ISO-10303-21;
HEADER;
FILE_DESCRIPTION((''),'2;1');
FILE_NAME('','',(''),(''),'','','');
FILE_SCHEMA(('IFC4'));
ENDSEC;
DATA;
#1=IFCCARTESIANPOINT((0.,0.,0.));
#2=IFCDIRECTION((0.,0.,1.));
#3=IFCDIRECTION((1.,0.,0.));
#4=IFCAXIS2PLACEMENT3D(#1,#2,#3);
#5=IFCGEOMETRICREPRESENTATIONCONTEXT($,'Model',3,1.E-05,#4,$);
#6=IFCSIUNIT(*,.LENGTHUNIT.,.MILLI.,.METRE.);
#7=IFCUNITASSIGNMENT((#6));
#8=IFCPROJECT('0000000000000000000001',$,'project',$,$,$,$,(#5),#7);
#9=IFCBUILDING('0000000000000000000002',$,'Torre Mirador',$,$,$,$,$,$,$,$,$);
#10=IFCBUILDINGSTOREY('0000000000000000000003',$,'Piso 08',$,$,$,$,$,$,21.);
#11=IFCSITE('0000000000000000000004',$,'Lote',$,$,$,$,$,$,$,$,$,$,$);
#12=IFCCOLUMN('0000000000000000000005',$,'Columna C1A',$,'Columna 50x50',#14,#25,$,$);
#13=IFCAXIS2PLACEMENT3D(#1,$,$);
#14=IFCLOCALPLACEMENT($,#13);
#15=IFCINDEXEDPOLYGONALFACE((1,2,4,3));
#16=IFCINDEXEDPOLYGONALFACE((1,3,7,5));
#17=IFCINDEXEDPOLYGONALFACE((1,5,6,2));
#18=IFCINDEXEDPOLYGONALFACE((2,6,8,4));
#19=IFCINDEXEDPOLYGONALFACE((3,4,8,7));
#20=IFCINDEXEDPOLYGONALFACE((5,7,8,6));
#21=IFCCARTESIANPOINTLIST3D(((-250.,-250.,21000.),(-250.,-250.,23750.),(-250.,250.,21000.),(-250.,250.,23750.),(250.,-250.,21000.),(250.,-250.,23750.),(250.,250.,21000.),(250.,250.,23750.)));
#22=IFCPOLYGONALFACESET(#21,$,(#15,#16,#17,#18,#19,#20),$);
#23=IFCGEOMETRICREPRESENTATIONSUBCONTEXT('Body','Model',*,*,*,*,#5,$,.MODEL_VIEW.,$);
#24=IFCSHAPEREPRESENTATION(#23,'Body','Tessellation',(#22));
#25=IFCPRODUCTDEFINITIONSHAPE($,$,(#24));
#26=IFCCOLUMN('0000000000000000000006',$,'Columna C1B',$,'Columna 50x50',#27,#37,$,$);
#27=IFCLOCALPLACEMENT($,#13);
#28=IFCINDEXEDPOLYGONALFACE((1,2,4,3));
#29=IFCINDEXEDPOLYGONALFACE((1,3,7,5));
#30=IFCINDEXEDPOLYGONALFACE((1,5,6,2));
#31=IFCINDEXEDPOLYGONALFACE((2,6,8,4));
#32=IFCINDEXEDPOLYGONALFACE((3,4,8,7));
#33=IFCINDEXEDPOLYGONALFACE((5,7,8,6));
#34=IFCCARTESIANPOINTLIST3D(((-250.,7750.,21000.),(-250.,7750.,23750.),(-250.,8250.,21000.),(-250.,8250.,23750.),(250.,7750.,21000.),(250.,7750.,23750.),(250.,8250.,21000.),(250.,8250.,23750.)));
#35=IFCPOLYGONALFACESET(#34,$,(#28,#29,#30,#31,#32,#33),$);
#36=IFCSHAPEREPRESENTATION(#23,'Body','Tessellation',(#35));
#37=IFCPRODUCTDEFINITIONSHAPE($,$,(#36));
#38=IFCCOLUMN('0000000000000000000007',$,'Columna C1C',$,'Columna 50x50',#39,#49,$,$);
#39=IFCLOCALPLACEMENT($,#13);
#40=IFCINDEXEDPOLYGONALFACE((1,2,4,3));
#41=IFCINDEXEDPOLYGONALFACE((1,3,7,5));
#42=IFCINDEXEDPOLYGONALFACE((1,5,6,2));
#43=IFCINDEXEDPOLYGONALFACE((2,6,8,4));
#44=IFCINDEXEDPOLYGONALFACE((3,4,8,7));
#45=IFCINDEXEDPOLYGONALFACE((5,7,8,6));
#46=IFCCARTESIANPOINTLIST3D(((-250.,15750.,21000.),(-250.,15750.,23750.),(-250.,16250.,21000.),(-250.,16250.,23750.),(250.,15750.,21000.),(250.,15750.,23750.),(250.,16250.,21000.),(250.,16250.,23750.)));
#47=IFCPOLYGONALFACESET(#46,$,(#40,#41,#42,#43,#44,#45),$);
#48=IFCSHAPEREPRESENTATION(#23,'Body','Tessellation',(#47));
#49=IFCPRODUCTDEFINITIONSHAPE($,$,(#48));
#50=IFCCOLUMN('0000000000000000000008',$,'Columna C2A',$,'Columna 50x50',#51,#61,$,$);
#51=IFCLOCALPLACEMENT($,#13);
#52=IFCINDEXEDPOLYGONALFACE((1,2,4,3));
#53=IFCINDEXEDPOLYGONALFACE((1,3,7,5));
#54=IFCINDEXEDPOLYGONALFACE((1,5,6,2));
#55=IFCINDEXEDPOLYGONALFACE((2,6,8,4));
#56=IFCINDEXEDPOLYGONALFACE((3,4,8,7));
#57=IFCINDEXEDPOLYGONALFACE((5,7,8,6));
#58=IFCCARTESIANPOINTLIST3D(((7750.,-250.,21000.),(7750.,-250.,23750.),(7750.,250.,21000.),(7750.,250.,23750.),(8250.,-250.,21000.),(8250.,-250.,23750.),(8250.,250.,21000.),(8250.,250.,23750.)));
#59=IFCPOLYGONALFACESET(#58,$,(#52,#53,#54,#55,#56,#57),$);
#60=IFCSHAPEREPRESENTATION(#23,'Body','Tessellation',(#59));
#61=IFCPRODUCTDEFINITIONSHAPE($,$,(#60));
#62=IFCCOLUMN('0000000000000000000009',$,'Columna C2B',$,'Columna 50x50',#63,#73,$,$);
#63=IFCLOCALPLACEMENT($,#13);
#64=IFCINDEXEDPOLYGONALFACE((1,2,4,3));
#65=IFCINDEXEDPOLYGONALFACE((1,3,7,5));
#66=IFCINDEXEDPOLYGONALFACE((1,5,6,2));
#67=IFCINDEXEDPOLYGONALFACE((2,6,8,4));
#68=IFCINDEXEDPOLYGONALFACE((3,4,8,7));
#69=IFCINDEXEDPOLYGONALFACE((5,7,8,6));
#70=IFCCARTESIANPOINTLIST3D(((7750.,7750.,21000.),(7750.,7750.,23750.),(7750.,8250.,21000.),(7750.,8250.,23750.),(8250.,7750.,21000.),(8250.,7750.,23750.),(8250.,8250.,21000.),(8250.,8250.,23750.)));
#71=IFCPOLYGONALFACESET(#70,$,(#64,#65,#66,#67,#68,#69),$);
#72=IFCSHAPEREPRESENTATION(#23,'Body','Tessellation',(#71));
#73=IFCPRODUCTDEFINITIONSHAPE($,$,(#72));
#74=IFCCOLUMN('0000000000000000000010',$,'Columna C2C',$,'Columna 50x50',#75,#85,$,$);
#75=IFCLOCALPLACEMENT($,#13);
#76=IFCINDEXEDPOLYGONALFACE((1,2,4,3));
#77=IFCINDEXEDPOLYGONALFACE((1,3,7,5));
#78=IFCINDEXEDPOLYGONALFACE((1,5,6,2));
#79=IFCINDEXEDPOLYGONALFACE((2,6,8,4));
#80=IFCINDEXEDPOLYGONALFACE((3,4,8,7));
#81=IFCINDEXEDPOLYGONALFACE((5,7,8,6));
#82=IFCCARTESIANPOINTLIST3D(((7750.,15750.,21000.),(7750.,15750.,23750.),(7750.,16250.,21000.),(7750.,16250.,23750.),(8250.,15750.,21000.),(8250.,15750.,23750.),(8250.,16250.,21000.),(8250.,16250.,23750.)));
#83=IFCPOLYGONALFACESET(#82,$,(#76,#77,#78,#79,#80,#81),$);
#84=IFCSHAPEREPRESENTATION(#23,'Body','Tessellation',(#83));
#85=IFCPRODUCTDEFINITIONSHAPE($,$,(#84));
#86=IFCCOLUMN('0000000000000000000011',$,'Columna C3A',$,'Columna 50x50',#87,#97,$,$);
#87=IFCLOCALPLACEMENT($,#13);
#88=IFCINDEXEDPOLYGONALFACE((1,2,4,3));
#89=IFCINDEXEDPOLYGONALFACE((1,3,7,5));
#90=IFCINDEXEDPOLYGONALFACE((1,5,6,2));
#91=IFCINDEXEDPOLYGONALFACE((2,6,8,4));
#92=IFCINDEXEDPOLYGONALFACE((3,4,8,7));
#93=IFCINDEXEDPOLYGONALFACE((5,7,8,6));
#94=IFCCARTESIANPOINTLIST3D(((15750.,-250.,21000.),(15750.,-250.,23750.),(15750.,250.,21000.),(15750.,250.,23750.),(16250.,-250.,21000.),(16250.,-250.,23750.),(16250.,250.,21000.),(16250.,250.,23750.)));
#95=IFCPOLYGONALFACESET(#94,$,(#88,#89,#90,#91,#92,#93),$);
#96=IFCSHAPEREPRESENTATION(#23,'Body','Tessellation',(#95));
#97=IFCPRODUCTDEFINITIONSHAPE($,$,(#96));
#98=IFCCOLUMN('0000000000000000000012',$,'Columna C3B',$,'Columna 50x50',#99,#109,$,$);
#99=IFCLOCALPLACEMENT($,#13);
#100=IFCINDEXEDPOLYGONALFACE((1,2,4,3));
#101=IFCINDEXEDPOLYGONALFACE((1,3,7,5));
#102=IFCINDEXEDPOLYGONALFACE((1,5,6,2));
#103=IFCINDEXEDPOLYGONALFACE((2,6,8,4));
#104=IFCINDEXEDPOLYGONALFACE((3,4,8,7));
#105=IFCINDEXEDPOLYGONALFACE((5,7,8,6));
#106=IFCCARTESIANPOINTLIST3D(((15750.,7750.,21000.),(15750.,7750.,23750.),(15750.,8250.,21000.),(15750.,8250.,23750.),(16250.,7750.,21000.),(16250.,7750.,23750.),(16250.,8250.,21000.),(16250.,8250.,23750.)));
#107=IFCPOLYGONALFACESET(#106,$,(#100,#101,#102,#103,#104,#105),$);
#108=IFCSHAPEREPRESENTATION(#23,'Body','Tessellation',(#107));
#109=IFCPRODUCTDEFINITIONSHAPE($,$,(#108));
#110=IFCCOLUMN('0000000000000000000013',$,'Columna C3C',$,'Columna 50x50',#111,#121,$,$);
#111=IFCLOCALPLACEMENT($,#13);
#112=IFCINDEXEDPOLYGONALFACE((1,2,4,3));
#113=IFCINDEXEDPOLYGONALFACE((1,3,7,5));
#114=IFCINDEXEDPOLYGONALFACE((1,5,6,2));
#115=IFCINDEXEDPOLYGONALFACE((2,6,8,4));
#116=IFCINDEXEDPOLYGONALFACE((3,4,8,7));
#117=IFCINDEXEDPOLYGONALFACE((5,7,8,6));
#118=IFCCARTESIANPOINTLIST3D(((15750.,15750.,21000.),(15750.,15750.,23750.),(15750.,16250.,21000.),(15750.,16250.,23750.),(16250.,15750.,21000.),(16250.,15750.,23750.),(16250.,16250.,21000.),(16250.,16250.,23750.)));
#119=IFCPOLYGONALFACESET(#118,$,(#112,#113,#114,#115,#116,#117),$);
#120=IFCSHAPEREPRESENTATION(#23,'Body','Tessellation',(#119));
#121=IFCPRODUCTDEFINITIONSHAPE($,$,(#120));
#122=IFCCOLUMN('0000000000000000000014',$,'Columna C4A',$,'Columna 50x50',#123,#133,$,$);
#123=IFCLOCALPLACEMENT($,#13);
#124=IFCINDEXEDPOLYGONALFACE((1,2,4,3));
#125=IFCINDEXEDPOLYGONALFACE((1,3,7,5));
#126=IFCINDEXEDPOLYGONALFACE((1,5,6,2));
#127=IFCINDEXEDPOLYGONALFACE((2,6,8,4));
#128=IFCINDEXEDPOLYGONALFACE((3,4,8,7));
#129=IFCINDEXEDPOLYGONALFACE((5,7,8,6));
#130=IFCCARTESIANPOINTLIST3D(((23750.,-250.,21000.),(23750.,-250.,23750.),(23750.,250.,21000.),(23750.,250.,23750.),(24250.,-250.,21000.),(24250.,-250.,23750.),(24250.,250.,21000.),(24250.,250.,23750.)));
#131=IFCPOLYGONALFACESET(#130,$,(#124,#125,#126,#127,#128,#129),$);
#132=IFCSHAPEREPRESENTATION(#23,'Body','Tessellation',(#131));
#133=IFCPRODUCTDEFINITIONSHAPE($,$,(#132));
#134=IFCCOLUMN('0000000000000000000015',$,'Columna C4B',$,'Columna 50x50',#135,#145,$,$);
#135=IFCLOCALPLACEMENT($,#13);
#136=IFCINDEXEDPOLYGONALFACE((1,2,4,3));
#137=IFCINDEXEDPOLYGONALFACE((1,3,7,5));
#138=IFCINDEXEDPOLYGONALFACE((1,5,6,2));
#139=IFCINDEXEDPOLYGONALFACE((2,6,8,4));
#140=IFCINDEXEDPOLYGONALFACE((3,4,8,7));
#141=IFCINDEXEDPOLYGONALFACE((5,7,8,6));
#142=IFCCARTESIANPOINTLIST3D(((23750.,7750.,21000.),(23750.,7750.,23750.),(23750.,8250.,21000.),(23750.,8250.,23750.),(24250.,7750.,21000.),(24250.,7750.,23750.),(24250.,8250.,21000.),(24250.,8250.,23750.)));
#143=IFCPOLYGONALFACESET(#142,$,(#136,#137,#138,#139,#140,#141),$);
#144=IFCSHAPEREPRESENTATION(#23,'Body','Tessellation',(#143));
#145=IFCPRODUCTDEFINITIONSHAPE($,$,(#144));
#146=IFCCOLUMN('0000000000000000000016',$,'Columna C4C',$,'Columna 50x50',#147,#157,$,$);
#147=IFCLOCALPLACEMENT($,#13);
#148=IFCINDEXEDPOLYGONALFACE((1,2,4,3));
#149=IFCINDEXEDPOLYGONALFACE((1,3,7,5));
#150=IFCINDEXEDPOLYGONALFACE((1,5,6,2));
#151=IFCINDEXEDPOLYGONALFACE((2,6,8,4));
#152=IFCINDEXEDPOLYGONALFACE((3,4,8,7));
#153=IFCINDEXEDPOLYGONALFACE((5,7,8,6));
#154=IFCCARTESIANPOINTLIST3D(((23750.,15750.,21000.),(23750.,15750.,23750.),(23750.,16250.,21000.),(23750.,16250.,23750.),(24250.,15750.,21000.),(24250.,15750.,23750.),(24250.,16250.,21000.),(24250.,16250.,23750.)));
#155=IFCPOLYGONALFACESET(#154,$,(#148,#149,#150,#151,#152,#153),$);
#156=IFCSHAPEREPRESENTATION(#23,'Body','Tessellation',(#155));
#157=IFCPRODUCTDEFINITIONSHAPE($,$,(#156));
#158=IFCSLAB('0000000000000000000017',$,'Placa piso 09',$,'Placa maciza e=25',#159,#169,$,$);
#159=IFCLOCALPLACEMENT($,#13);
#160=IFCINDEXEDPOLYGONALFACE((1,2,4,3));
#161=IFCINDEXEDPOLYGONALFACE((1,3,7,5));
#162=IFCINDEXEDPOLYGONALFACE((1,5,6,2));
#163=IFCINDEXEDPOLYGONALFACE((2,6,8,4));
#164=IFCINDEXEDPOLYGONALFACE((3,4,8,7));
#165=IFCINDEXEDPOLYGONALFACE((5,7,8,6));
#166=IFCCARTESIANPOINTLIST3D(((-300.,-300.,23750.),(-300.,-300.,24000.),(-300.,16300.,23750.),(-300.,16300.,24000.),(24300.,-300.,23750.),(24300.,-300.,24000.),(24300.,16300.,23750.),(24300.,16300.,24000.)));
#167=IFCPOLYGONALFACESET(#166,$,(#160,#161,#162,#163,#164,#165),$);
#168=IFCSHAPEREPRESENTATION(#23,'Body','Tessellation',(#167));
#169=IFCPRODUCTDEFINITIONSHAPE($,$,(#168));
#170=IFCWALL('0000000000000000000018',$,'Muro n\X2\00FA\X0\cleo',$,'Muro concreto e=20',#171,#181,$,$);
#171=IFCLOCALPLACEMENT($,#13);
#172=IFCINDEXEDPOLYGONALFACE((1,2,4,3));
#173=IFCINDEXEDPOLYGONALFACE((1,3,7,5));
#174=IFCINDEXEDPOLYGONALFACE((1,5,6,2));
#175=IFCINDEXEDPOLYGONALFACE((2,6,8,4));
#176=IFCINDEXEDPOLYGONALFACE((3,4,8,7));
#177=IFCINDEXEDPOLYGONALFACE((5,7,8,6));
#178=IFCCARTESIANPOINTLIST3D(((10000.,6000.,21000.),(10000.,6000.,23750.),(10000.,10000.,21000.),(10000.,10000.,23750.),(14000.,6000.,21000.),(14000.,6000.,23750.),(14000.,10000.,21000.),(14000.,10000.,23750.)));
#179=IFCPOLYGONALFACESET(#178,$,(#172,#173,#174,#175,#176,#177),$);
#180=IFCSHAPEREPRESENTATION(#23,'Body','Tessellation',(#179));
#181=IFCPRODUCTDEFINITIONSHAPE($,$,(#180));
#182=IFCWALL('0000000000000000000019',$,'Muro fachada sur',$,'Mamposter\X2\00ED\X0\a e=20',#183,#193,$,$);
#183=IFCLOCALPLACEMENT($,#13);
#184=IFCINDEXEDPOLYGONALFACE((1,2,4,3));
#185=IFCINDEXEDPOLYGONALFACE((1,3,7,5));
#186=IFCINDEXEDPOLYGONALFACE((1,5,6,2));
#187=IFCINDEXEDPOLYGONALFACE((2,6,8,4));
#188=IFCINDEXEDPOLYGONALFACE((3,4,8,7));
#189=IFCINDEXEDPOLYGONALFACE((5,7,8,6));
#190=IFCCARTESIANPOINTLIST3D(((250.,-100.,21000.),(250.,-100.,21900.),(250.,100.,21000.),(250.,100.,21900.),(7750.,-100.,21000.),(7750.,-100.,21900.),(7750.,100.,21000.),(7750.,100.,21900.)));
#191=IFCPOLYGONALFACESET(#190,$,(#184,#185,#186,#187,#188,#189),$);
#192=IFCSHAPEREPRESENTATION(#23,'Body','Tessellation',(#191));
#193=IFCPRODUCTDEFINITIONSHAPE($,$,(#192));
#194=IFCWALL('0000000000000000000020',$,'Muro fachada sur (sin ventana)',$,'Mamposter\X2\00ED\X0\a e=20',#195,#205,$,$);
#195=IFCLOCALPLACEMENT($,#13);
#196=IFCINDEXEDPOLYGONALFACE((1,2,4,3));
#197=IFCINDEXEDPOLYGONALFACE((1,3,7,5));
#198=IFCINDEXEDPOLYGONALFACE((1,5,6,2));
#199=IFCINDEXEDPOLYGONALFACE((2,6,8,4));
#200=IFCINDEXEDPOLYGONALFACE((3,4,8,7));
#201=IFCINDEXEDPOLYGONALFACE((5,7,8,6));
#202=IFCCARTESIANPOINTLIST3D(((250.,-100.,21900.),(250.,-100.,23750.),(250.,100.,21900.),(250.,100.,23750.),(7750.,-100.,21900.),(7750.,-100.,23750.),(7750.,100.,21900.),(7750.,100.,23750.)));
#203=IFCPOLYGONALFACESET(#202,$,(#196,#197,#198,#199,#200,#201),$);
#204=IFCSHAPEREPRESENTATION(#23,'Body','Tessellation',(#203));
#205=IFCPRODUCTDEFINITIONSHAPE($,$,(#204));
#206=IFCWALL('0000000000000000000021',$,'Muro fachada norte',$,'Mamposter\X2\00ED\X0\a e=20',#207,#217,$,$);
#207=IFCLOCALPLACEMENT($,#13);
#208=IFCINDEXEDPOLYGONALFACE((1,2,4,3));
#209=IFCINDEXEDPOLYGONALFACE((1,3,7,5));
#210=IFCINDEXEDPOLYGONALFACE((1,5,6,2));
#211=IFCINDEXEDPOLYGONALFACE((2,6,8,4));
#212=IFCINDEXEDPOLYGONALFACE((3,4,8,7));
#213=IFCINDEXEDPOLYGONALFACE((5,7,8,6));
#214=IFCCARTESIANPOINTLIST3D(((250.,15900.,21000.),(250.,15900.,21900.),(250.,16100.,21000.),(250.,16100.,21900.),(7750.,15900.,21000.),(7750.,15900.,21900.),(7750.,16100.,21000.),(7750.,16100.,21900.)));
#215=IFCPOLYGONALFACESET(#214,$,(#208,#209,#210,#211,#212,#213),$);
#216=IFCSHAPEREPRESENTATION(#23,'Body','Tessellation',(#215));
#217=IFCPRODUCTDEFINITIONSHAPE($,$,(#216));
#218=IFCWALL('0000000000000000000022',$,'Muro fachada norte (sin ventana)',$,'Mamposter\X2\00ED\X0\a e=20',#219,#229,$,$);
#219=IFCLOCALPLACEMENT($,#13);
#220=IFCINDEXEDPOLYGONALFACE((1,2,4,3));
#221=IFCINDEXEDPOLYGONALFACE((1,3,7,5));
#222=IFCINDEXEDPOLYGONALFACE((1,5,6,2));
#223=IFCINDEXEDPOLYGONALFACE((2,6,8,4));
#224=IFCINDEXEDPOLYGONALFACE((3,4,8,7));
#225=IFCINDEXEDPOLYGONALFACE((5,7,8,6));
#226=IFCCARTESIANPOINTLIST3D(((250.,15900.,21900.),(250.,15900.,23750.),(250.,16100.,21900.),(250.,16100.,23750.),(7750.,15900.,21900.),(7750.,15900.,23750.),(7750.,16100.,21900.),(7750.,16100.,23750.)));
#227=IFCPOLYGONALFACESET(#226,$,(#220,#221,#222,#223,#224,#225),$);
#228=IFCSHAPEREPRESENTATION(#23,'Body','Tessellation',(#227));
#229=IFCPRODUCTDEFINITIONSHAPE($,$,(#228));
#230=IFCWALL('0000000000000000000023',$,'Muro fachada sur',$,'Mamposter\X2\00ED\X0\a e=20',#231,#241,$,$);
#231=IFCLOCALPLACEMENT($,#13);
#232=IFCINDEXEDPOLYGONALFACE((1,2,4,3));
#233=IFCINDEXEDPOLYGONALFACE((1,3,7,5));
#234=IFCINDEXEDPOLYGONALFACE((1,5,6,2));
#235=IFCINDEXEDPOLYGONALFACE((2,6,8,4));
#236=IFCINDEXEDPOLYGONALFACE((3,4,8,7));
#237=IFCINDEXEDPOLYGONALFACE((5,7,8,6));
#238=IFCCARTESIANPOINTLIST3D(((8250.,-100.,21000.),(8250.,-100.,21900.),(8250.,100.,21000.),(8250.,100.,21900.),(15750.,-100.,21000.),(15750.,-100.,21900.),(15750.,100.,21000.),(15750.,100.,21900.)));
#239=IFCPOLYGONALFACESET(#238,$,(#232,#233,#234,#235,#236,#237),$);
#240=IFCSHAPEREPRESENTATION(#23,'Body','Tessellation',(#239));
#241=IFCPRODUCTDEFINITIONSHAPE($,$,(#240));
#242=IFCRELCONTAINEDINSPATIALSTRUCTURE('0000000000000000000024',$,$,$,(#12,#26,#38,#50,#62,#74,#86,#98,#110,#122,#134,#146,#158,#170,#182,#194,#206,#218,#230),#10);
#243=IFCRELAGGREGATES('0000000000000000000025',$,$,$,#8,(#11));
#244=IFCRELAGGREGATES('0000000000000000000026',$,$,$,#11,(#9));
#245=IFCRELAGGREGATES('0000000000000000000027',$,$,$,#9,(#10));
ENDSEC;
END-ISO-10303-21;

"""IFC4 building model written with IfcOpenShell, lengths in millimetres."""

from ifc_helpers import new_model, si_unit, frame, origin_with_axes, place, context, subcontext, project, spatial, indexed_curve, outline, extrude, element, save


model = new_model("IFC4")

# Units and contexts
model_context = context("Model", 3, precision=1e-05, world=origin_with_axes())
body_context = subcontext(model_context, "Body", "Model", "MODEL_VIEW")
ifc_project = project(units=[si_unit("LENGTHUNIT", "METRE", prefix="MILLI")], contexts=[model_context])

# Site, building, storey
site = spatial("IfcSite", under=ifc_project, Name="Lote")
building = spatial("IfcBuilding", under=site, Name="Torre Mirador")
storey = spatial("IfcBuildingStorey", under=building, Name="Piso 08", Elevation=21.0)

# Columns
for number, where, z_axis, x_axis, name in (
    (1, (-250.0, -250.0, 21000.0), (0.0, 0.0, 1.0), (1.0, 0.0, 0.0), "Columna C1A"),
    (2, (-250.0, 7750.0, 21000.0), (0.0, 0.0, 1.0), (1.0, 0.0, 0.0), "Columna C1B"),
    (3, (-250.0, 15750.0, 21000.0), (0.0, 0.0, 1.0), (1.0, 0.0, 0.0), "Columna C1C"),
    (4, (7750.0, -250.0, 21000.0), (0.0, 0.0, 1.0), (1.0, 0.0, 0.0), "Columna C2A"),
    (5, (7750.0, 7750.0, 21000.0), (0.0, 0.0, 1.0), (1.0, 0.0, 0.0), "Columna C2B"),
    (6, (7750.0, 15750.0, 21000.0), (0.0, 0.0, 1.0), (1.0, 0.0, 0.0), "Columna C2C"),
    (7, (15750.0, -250.0, 21000.0), (0.0, 0.0, 1.0), (1.0, 0.0, 0.0), "Columna C3A"),
    (8, (15750.0, 7750.0, 21000.0), (0.0, 0.0, 1.0), (1.0, 0.0, 0.0), "Columna C3B"),
    (9, (15750.0, 15750.0, 21000.0), (0.0, 0.0, 1.0), (1.0, 0.0, 0.0), "Columna C3C"),
    (10, (23750.0, -250.0, 21000.0), (0.0, 0.0, 1.0), (1.0, 0.0, 0.0), "Columna C4A"),
    (11, (23750.0, 7750.0, 21000.0), (0.0, 0.0, 1.0), (1.0, 0.0, 0.0), "Columna C4B"),
    (12, (23750.0, 15750.0, 21000.0), (0.0, 0.0, 1.0), (1.0, 0.0, 0.0), "Columna C4C"),
):
    element("IfcColumn", number, at=place(None, frame(where, z_axis=z_axis, x_axis=x_axis)), inside=storey, Name=name, ObjectType="Columna 50x50", context=body_context, shape_type="SweptSolid", body=[
        extrude(outline(indexed_curve([(0.0, 0.0), (0.0, 500.0), (500.0, 500.0), (500.0, 0.0), (0.0, 0.0)], self_intersect=False)), origin_with_axes(), (0.0, 0.0, 1.0), 2750.0),
    ])

# Slab
slab_placement = place(None, frame((-300.0, -300.0, 23750.0), z_axis=(0.0, 0.0, 1.0), x_axis=(1.0, 0.0, 0.0)))
element("IfcSlab", 13, at=slab_placement, inside=storey, Name="Placa piso 09", ObjectType="Placa maciza e=25", context=body_context, shape_type="SweptSolid", body=[
    extrude(outline(indexed_curve([(0.0, 0.0), (0.0, 16600.0), (24600.0, 16600.0), (24600.0, 0.0), (0.0, 0.0)], self_intersect=False)), origin_with_axes(), (0.0, 0.0, 1.0), 250.0),
])

# Walls
wall_1_placement = place(None, frame((10000.0, 6000.0, 21000.0), z_axis=(0.0, 0.0, 1.0), x_axis=(1.0, 0.0, 0.0)))
element("IfcWall", 14, at=wall_1_placement, inside=storey, Name="Muro núcleo", ObjectType="Muro concreto e=20", context=body_context, shape_type="SweptSolid", body=[
    extrude(outline(indexed_curve([(0.0, 0.0), (0.0, 4000.0), (4000.0, 4000.0), (4000.0, 0.0), (0.0, 0.0)], self_intersect=False)), origin_with_axes(), (0.0, 0.0, 1.0), 2750.0),
])
wall_2_placement = place(None, frame((250.0, -100.0, 21000.0), z_axis=(0.0, 0.0, 1.0), x_axis=(1.0, 0.0, 0.0)))
element("IfcWall", 15, at=wall_2_placement, inside=storey, Name="Muro fachada sur", ObjectType="Mampostería e=20", context=body_context, shape_type="SweptSolid", body=[
    extrude(outline(indexed_curve([(0.0, 0.0), (0.0, 200.0), (7500.0, 200.0), (7500.0, 0.0), (0.0, 0.0)], self_intersect=False)), origin_with_axes(), (0.0, 0.0, 1.0), 900.0),
])
wall_3_placement = place(None, frame((250.0, -100.0, 21900.0), z_axis=(0.0, 0.0, 1.0), x_axis=(1.0, 0.0, 0.0)))
element("IfcWall", 16, at=wall_3_placement, inside=storey, Name="Muro fachada sur (sin ventana)", ObjectType="Mampostería e=20", context=body_context, shape_type="SweptSolid", body=[
    extrude(outline(indexed_curve([(0.0, 0.0), (0.0, 200.0), (7500.0, 200.0), (7500.0, 0.0), (0.0, 0.0)], self_intersect=False)), origin_with_axes(), (0.0, 0.0, 1.0), 1850.0),
])
wall_4_placement = place(None, frame((250.0, 15900.0, 21000.0), z_axis=(0.0, 0.0, 1.0), x_axis=(1.0, 0.0, 0.0)))
element("IfcWall", 17, at=wall_4_placement, inside=storey, Name="Muro fachada norte", ObjectType="Mampostería e=20", context=body_context, shape_type="SweptSolid", body=[
    extrude(outline(indexed_curve([(0.0, 0.0), (0.0, 200.0), (7500.0, 200.0), (7500.0, 0.0), (0.0, 0.0)], self_intersect=False)), origin_with_axes(), (0.0, 0.0, 1.0), 900.0),
])
wall_5_placement = place(None, frame((250.0, 15900.0, 21900.0), z_axis=(0.0, 0.0, 1.0), x_axis=(1.0, 0.0, 0.0)))
element("IfcWall", 18, at=wall_5_placement, inside=storey, Name="Muro fachada norte (sin ventana)", ObjectType="Mampostería e=20", context=body_context, shape_type="SweptSolid", body=[
    extrude(outline(indexed_curve([(0.0, 0.0), (0.0, 200.0), (7500.0, 200.0), (7500.0, 0.0), (0.0, 0.0)], self_intersect=False)), origin_with_axes(), (0.0, 0.0, 1.0), 1850.0),
])
wall_6_placement = place(None, frame((8250.0, -100.0, 21000.0), z_axis=(0.0, 0.0, 1.0), x_axis=(1.0, 0.0, 0.0)))
element("IfcWall", 19, at=wall_6_placement, inside=storey, Name="Muro fachada sur", ObjectType="Mampostería e=20", context=body_context, shape_type="SweptSolid", body=[
    extrude(outline(indexed_curve([(0.0, 0.0), (0.0, 200.0), (7500.0, 200.0), (7500.0, 0.0), (0.0, 0.0)], self_intersect=False)), origin_with_axes(), (0.0, 0.0, 1.0), 900.0),
])

save(model, "model.ifc")
